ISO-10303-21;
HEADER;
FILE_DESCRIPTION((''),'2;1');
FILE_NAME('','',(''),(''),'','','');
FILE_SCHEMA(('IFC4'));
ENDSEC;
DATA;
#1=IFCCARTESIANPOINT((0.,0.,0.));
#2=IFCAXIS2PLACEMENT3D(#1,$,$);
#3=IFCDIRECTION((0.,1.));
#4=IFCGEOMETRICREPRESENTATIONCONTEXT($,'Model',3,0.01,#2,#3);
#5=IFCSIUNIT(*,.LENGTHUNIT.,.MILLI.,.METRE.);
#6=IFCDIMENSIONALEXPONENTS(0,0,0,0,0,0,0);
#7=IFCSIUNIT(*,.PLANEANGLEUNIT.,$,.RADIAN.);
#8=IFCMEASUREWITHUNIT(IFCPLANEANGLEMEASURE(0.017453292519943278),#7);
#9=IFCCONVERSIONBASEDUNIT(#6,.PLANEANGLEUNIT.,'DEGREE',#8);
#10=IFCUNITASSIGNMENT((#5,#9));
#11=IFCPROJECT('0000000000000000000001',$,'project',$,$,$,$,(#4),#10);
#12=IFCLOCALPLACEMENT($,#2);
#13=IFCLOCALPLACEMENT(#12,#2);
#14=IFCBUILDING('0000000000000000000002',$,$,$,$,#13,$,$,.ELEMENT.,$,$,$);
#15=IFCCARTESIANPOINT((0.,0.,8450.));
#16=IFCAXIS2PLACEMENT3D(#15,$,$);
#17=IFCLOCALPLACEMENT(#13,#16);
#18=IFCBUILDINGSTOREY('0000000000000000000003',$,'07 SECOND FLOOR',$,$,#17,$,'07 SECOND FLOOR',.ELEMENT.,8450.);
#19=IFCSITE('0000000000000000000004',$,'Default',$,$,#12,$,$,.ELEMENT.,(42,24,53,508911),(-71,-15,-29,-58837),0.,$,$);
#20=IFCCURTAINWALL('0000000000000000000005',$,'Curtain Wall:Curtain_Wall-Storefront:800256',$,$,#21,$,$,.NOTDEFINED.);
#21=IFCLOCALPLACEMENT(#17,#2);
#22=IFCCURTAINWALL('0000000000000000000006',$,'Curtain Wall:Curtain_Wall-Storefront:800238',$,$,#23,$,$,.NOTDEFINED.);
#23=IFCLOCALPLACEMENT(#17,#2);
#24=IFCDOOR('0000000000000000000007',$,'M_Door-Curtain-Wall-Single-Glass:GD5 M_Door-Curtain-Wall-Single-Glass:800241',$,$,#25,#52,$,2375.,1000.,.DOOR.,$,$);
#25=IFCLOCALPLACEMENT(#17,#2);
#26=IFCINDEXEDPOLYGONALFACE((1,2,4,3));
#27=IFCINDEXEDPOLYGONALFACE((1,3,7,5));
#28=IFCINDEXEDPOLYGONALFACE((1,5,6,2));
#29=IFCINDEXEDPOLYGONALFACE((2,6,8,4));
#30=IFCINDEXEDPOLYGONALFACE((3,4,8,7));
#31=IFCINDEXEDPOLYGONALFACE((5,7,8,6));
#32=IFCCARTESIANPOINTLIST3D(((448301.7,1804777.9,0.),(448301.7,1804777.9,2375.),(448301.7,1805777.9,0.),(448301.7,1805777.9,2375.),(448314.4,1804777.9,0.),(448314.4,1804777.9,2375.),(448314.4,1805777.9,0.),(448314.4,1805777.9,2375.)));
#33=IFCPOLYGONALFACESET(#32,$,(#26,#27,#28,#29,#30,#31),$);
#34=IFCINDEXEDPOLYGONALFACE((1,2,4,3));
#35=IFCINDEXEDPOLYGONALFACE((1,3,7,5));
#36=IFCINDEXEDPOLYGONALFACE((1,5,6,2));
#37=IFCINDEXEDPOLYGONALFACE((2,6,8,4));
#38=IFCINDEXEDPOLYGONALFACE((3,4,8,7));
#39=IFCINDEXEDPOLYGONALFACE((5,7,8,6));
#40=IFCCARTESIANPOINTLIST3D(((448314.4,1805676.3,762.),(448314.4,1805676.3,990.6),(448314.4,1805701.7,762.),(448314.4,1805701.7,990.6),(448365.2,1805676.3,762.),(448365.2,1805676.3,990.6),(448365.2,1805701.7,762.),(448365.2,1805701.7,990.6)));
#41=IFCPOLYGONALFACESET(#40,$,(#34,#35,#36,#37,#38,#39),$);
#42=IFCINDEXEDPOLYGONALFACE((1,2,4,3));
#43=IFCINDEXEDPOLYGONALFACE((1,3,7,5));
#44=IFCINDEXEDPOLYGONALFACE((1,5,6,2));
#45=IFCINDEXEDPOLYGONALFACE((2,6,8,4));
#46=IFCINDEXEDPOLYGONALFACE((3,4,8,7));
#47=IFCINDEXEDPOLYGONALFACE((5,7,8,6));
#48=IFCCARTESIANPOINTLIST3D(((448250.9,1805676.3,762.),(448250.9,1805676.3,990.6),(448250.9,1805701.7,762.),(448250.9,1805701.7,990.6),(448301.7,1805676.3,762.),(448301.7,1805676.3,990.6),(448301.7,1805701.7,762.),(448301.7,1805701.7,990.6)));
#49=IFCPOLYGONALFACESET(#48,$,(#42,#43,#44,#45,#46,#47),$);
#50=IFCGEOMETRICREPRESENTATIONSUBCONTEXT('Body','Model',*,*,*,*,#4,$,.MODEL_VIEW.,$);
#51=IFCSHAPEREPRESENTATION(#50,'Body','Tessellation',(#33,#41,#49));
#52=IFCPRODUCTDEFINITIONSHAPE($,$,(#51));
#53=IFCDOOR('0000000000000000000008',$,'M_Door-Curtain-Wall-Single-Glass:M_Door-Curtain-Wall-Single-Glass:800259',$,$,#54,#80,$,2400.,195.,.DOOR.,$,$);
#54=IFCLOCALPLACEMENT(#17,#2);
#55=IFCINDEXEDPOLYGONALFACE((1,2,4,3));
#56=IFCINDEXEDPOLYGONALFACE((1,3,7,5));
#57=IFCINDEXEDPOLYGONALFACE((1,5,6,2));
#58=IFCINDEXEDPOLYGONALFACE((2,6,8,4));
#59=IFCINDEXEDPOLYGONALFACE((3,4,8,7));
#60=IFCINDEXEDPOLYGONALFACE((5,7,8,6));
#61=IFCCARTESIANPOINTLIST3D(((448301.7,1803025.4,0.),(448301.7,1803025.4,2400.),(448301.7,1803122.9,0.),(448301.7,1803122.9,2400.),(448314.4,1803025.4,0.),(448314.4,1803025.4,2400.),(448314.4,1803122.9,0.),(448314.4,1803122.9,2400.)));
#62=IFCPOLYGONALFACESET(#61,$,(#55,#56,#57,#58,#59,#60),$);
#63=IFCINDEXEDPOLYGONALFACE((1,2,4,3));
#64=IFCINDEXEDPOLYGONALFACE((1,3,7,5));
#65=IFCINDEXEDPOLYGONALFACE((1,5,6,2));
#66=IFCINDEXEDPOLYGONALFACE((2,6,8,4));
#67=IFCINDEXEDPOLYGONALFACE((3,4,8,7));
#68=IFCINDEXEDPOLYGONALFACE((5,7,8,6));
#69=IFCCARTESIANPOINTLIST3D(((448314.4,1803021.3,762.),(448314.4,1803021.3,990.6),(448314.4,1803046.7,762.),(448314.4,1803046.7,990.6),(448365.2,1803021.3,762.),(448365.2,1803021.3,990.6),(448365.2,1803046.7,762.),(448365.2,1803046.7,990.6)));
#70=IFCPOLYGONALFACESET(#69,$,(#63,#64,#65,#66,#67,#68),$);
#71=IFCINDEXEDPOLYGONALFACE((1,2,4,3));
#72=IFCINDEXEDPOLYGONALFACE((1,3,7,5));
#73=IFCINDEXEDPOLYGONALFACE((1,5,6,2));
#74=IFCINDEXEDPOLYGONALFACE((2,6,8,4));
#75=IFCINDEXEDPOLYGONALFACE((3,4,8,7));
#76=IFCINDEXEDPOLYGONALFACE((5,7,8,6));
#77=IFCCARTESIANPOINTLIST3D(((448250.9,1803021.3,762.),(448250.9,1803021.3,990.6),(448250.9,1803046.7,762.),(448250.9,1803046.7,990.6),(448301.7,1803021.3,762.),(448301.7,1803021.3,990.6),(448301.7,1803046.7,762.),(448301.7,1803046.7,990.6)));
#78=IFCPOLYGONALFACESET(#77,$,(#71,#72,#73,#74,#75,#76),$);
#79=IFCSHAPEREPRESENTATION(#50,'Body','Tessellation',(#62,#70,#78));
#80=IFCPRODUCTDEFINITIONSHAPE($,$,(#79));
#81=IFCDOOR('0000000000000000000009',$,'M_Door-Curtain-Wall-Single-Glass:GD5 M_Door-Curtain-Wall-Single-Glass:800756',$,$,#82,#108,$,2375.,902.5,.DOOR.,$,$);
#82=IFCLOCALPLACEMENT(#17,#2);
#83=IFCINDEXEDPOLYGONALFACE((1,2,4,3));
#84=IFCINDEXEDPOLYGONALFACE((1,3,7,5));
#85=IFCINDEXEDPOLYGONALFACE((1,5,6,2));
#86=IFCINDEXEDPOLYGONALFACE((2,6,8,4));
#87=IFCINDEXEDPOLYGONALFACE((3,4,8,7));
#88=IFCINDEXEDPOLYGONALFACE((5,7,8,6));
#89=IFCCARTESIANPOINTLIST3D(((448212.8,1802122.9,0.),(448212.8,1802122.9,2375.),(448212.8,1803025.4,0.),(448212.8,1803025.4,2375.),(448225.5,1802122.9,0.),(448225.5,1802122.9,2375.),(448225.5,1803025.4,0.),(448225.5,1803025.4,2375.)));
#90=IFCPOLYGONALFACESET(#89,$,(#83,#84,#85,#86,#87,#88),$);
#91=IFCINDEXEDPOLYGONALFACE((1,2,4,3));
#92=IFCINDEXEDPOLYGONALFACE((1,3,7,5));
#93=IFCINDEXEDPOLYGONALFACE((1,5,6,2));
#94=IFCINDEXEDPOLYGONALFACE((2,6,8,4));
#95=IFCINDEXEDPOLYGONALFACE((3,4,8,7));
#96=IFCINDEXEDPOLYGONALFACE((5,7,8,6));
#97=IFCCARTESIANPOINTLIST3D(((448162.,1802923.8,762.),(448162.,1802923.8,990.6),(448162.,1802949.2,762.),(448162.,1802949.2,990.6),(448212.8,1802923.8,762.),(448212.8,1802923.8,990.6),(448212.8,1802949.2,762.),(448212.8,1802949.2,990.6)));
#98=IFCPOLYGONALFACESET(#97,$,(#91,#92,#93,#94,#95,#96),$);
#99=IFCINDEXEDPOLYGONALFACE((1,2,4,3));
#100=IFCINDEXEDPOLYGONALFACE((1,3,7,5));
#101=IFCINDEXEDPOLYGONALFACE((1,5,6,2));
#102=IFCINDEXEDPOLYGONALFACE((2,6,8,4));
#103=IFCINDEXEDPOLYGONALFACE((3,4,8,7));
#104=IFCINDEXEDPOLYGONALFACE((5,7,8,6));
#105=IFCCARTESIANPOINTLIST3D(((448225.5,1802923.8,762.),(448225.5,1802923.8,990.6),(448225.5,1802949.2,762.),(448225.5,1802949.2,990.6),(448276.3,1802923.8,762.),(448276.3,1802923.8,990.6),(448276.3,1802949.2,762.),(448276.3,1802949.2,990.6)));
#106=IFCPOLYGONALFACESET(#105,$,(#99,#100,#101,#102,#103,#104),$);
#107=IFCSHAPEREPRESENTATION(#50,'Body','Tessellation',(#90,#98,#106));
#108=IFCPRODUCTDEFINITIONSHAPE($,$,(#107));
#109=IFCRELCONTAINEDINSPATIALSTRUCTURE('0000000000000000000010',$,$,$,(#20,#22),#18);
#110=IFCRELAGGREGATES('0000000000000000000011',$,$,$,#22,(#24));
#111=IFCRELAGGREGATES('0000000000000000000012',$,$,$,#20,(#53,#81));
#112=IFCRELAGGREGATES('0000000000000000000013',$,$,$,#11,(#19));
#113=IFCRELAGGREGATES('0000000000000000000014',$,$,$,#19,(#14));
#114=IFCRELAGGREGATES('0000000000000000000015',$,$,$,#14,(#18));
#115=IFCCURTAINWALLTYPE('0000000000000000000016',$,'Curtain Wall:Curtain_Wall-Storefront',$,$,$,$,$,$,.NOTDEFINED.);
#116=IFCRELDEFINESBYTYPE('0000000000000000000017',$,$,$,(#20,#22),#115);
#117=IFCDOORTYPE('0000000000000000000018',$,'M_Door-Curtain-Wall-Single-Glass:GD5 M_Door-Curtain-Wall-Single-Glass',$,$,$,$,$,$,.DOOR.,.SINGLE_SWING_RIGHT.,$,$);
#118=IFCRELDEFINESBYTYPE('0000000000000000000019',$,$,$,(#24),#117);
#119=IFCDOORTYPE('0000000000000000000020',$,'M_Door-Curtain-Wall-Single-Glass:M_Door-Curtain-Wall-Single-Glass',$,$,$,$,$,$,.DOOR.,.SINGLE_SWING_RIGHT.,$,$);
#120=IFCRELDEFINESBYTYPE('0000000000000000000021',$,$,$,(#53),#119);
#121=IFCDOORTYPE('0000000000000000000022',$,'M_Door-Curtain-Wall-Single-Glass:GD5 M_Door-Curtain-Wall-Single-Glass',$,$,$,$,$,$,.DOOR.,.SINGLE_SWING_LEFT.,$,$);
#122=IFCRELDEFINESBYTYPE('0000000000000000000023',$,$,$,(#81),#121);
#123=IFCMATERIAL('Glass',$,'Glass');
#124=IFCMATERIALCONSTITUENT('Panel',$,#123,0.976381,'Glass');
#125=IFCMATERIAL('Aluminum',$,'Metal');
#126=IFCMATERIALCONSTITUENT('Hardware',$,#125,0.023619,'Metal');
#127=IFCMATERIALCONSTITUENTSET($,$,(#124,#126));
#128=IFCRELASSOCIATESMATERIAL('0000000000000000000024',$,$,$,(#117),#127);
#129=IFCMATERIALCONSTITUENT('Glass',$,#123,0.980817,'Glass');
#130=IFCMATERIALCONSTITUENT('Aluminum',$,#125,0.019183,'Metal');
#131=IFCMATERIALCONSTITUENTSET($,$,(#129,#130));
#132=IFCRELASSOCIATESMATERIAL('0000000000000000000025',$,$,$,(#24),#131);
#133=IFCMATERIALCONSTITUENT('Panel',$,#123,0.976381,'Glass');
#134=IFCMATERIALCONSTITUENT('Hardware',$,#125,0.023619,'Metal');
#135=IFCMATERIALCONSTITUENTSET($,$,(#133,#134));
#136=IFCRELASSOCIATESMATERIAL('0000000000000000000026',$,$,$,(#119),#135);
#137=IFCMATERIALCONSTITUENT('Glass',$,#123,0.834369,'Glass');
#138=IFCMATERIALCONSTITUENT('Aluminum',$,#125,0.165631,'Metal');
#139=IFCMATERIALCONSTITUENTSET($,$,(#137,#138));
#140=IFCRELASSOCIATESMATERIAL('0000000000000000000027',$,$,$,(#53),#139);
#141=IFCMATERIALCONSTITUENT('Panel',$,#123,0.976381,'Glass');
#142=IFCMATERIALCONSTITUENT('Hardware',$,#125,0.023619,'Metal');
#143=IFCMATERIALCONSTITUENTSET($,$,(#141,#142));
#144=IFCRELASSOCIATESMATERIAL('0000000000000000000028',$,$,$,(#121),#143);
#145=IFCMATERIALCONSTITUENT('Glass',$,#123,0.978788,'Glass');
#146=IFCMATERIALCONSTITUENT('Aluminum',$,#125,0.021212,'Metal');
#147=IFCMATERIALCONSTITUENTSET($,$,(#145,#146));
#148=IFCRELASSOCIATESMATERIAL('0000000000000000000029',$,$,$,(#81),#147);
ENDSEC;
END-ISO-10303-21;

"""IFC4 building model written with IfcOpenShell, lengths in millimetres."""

from ifc_helpers import new_model, entity, si_unit, converted_unit, direction, frame, origin, place, context, subcontext, project, spatial, indexed_curve, outline, extrude, source, transform, mapped, material, constituent, constituent_set, type_object, type_shapes, element, aggregate, save


model = new_model("IFC4")

# Units and contexts
model_context = context("Model", 3, precision=0.01, world=origin(), true_north=direction((0.0, 1.0)))
body_context = subcontext(model_context, "Body", "Model", "MODEL_VIEW")
ifc_project = project(units=[si_unit("LENGTHUNIT", "METRE", prefix="MILLI"), converted_unit("PLANEANGLEUNIT", "DEGREE", entity("IfcPlaneAngleMeasure", 0.017453292519943278), si_unit("PLANEANGLEUNIT", "RADIAN"), dimensions=[0, 0, 0, 0, 0, 0, 0])], contexts=[model_context])

# Site, building, storey
site_placement = place(None, origin())
site = spatial("IfcSite", under=ifc_project, at=site_placement, Name="Default", CompositionType="ELEMENT", RefLatitude=(42, 24, 53, 508911), RefLongitude=(-71, -15, -29, -58837), RefElevation=0.0)
building_placement = place(site_placement, origin())
building = spatial("IfcBuilding", under=site, at=building_placement, CompositionType="ELEMENT")
storey_placement = place(building_placement, frame((0.0, 0.0, 8450.0)))
storey = spatial("IfcBuildingStorey", under=building, at=storey_placement, Name="07 SECOND FLOOR", LongName="07 SECOND FLOOR", CompositionType="ELEMENT", Elevation=8450.0)

# Curtain wall
curtain_wall_type = type_object("IfcCurtainWallType", Name="Curtain Wall:Curtain_Wall-Storefront", PredefinedType="NOTDEFINED")
curtain_wall_1_placement = place(storey_placement, frame((0.0, 0.0, -8450.0)))
curtain_wall_1 = element("IfcCurtainWall", 1, at=curtain_wall_1_placement, inside=storey, type_object=curtain_wall_type, Name="Curtain Wall:Curtain_Wall-Storefront:800256", PredefinedType="NOTDEFINED")

# Curtain wall
curtain_wall_2_placement = place(storey_placement, frame((0.0, 0.0, -8450.0)))
curtain_wall_2 = element("IfcCurtainWall", 2, at=curtain_wall_2_placement, inside=storey, type_object=curtain_wall_type, Name="Curtain Wall:Curtain_Wall-Storefront:800238", PredefinedType="NOTDEFINED")

# Shared definitions
ifc_material_1 = material(Name="Glass", Category="Glass")

# Doors
ifc_constituent_1 = constituent(ifc_material_1, Name="Glass", Category="Glass", fraction=0.980817)
ifc_material_2 = material(Name="Aluminum", Category="Metal")
ifc_constituent_2 = constituent(ifc_material_2, Name="Aluminum", Category="Metal", fraction=0.019183)
ifc_constituent_set_1 = constituent_set(constituents=[ifc_constituent_1, ifc_constituent_2])
ifc_constituent_3 = constituent(ifc_material_1, Name="Panel", Category="Glass", fraction=0.976381)
ifc_constituent_4 = constituent(ifc_material_2, Name="Hardware", Category="Metal", fraction=0.023619)
ifc_constituent_set_2 = constituent_set(constituents=[ifc_constituent_3, ifc_constituent_4])
door_type_1 = type_object("IfcDoorType", Name="M_Door-Curtain-Wall-Single-Glass:GD5 M_Door-Curtain-Wall-Single-Glass", OperationType="SINGLE_SWING_RIGHT", PredefinedType="DOOR", material=ifc_constituent_set_2)
shared_shape_1 = source(origin(), body_context, "Body", "SweptSolid", [
    extrude(outline(indexed_curve([(-500.0, -6.4), (500.0, -6.4), (500.0, 6.4), (-500.0, 6.4), (-500.0, -6.4)], self_intersect=False)), frame((0.0, 44.5, 0.0), z_axis=(0.0, 0.0, 1.0), x_axis=(-1.0, 0.0, 0.0)), (0.0, 0.0, 1.0), 2375.0),
    extrude(outline(indexed_curve([(-25.4, -12.7), (25.4, -12.7), (25.4, 12.7), (-25.4, 12.7), (-25.4, -12.7)], self_intersect=False)), frame((-411.1, 76.2, 762.0), z_axis=(0.0, 0.0, 1.0), x_axis=(0.0, -1.0, 0.0)), (0.0, 0.0, 1.0), 228.6),
    extrude(outline(indexed_curve([(-25.4, -12.7), (25.4, -12.7), (25.4, 12.7), (-25.4, 12.7), (-25.4, -12.7)], self_intersect=False)), frame((-411.1, 12.7, 762.0), z_axis=(0.0, 0.0, 1.0), x_axis=(0.0, 1.0, 0.0)), (0.0, 0.0, 1.0), 228.6),
])
type_shapes(door_type_1, [shared_shape_1])
door_1_placement = place(curtain_wall_2_placement, frame((448263.6, 1805277.9, 8450.0), z_axis=(0.0, 0.0, 1.0), x_axis=(0.0, -1.0, 0.0)))
door_1 = element("IfcDoor", 3, at=door_1_placement, type_object=door_type_1, material=ifc_constituent_set_1, Name="M_Door-Curtain-Wall-Single-Glass:GD5 M_Door-Curtain-Wall-Single-Glass:800241", OverallHeight=2375.0, OverallWidth=1000.0, PredefinedType="DOOR", context=body_context, shape_type="MappedRepresentation", body=[
    mapped(shared_shape_1, transform((0.0, 0.0, 0.0), scale=1.0)),
])
aggregate(curtain_wall_2, [door_1])
ifc_constituent_5 = constituent(ifc_material_1, Name="Glass", Category="Glass", fraction=0.834369)
ifc_constituent_6 = constituent(ifc_material_2, Name="Aluminum", Category="Metal", fraction=0.165631)
ifc_constituent_set_3 = constituent_set(constituents=[ifc_constituent_5, ifc_constituent_6])
ifc_constituent_7 = constituent(ifc_material_1, Name="Panel", Category="Glass", fraction=0.976381)
ifc_constituent_8 = constituent(ifc_material_2, Name="Hardware", Category="Metal", fraction=0.023619)
ifc_constituent_set_4 = constituent_set(constituents=[ifc_constituent_7, ifc_constituent_8])
door_type_2 = type_object("IfcDoorType", Name="M_Door-Curtain-Wall-Single-Glass:M_Door-Curtain-Wall-Single-Glass", OperationType="SINGLE_SWING_RIGHT", PredefinedType="DOOR", material=ifc_constituent_set_4)
shared_shape_2 = source(origin(), body_context, "Body", "SweptSolid", [
    extrude(outline(indexed_curve([(-48.8, -6.4), (48.8, -6.4), (48.8, 6.4), (-48.8, 6.4), (-48.8, -6.4)], self_intersect=False)), frame((0.0, 44.5, 0.0), z_axis=(0.0, 0.0, 1.0), x_axis=(-1.0, 0.0, 0.0)), (0.0, 0.0, 1.0), 2400.0),
    extrude(outline(indexed_curve([(-25.4, -12.7), (25.4, -12.7), (25.4, 12.7), (-25.4, 12.7), (-25.4, -12.7)], self_intersect=False)), frame((40.1, 76.2, 762.0), z_axis=(0.0, 0.0, 1.0), x_axis=(0.0, -1.0, 0.0)), (0.0, 0.0, 1.0), 228.6),
    extrude(outline(indexed_curve([(-25.4, -12.7), (25.4, -12.7), (25.4, 12.7), (-25.4, 12.7), (-25.4, -12.7)], self_intersect=False)), frame((40.1, 12.7, 762.0), z_axis=(0.0, 0.0, 1.0), x_axis=(0.0, 1.0, 0.0)), (0.0, 0.0, 1.0), 228.6),
])
type_shapes(door_type_2, [shared_shape_2])
door_2_placement = place(curtain_wall_1_placement, frame((448263.6, 1803074.2, 8450.0), z_axis=(0.0, 0.0, 1.0), x_axis=(0.0, -1.0, 0.0)))
door_2 = element("IfcDoor", 4, at=door_2_placement, type_object=door_type_2, material=ifc_constituent_set_3, Name="M_Door-Curtain-Wall-Single-Glass:M_Door-Curtain-Wall-Single-Glass:800259", OverallHeight=2400.0, OverallWidth=195.0, PredefinedType="DOOR", context=body_context, shape_type="MappedRepresentation", body=[
    mapped(shared_shape_2, transform((0.0, 0.0, 0.0), scale=1.0)),
])
ifc_constituent_9 = constituent(ifc_material_1, Name="Glass", Category="Glass", fraction=0.978788)
ifc_constituent_10 = constituent(ifc_material_2, Name="Aluminum", Category="Metal", fraction=0.021212)
ifc_constituent_set_5 = constituent_set(constituents=[ifc_constituent_9, ifc_constituent_10])
ifc_constituent_11 = constituent(ifc_material_1, Name="Panel", Category="Glass", fraction=0.976381)
ifc_constituent_12 = constituent(ifc_material_2, Name="Hardware", Category="Metal", fraction=0.023619)
ifc_constituent_set_6 = constituent_set(constituents=[ifc_constituent_11, ifc_constituent_12])
door_type_3 = type_object("IfcDoorType", Name="M_Door-Curtain-Wall-Single-Glass:GD5 M_Door-Curtain-Wall-Single-Glass", OperationType="SINGLE_SWING_LEFT", PredefinedType="DOOR", material=ifc_constituent_set_6)
shared_shape_3 = source(origin(), body_context, "Body", "SweptSolid", [
    extrude(outline(indexed_curve([(-6.4, -451.3), (6.4, -451.3), (6.4, 451.3), (-6.4, 451.3), (-6.4, -451.3)], self_intersect=False)), frame((0.0, 44.5, 0.0), z_axis=(0.0, 0.0, 1.0), x_axis=(0.0, -1.0, 0.0)), (0.0, 0.0, 1.0), 2375.0),
    extrude(outline(indexed_curve([(-12.7, -25.4), (12.7, -25.4), (12.7, 25.4), (-12.7, 25.4), (-12.7, -25.4)], self_intersect=False)), frame((362.4, 76.2, 762.0), z_axis=(0.0, 0.0, 1.0), x_axis=(-1.0, 0.0, 0.0)), (0.0, 0.0, 1.0), 228.6),
    extrude(outline(indexed_curve([(-12.7, -25.4), (12.7, -25.4), (12.7, 25.4), (-12.7, 25.4), (-12.7, -25.4)], self_intersect=False)), frame((362.4, 12.7, 762.0)), (0.0, 0.0, 1.0), 228.6),
])
type_shapes(door_type_3, [shared_shape_3])
door_3_placement = place(curtain_wall_1_placement, frame((448263.6, 1802574.2, 8450.0), z_axis=(0.0, 0.0, 1.0), x_axis=(0.0, 1.0, 0.0)))
door_3 = element("IfcDoor", 5, at=door_3_placement, type_object=door_type_3, material=ifc_constituent_set_5, Name="M_Door-Curtain-Wall-Single-Glass:GD5 M_Door-Curtain-Wall-Single-Glass:800756", OverallHeight=2375.0, OverallWidth=902.5, PredefinedType="DOOR", context=body_context, shape_type="MappedRepresentation", body=[
    mapped(shared_shape_3, transform((0.0, 0.0, 0.0), scale=1.0)),
])
aggregate(curtain_wall_1, [door_2, door_3])

save(model, "model.ifc")
